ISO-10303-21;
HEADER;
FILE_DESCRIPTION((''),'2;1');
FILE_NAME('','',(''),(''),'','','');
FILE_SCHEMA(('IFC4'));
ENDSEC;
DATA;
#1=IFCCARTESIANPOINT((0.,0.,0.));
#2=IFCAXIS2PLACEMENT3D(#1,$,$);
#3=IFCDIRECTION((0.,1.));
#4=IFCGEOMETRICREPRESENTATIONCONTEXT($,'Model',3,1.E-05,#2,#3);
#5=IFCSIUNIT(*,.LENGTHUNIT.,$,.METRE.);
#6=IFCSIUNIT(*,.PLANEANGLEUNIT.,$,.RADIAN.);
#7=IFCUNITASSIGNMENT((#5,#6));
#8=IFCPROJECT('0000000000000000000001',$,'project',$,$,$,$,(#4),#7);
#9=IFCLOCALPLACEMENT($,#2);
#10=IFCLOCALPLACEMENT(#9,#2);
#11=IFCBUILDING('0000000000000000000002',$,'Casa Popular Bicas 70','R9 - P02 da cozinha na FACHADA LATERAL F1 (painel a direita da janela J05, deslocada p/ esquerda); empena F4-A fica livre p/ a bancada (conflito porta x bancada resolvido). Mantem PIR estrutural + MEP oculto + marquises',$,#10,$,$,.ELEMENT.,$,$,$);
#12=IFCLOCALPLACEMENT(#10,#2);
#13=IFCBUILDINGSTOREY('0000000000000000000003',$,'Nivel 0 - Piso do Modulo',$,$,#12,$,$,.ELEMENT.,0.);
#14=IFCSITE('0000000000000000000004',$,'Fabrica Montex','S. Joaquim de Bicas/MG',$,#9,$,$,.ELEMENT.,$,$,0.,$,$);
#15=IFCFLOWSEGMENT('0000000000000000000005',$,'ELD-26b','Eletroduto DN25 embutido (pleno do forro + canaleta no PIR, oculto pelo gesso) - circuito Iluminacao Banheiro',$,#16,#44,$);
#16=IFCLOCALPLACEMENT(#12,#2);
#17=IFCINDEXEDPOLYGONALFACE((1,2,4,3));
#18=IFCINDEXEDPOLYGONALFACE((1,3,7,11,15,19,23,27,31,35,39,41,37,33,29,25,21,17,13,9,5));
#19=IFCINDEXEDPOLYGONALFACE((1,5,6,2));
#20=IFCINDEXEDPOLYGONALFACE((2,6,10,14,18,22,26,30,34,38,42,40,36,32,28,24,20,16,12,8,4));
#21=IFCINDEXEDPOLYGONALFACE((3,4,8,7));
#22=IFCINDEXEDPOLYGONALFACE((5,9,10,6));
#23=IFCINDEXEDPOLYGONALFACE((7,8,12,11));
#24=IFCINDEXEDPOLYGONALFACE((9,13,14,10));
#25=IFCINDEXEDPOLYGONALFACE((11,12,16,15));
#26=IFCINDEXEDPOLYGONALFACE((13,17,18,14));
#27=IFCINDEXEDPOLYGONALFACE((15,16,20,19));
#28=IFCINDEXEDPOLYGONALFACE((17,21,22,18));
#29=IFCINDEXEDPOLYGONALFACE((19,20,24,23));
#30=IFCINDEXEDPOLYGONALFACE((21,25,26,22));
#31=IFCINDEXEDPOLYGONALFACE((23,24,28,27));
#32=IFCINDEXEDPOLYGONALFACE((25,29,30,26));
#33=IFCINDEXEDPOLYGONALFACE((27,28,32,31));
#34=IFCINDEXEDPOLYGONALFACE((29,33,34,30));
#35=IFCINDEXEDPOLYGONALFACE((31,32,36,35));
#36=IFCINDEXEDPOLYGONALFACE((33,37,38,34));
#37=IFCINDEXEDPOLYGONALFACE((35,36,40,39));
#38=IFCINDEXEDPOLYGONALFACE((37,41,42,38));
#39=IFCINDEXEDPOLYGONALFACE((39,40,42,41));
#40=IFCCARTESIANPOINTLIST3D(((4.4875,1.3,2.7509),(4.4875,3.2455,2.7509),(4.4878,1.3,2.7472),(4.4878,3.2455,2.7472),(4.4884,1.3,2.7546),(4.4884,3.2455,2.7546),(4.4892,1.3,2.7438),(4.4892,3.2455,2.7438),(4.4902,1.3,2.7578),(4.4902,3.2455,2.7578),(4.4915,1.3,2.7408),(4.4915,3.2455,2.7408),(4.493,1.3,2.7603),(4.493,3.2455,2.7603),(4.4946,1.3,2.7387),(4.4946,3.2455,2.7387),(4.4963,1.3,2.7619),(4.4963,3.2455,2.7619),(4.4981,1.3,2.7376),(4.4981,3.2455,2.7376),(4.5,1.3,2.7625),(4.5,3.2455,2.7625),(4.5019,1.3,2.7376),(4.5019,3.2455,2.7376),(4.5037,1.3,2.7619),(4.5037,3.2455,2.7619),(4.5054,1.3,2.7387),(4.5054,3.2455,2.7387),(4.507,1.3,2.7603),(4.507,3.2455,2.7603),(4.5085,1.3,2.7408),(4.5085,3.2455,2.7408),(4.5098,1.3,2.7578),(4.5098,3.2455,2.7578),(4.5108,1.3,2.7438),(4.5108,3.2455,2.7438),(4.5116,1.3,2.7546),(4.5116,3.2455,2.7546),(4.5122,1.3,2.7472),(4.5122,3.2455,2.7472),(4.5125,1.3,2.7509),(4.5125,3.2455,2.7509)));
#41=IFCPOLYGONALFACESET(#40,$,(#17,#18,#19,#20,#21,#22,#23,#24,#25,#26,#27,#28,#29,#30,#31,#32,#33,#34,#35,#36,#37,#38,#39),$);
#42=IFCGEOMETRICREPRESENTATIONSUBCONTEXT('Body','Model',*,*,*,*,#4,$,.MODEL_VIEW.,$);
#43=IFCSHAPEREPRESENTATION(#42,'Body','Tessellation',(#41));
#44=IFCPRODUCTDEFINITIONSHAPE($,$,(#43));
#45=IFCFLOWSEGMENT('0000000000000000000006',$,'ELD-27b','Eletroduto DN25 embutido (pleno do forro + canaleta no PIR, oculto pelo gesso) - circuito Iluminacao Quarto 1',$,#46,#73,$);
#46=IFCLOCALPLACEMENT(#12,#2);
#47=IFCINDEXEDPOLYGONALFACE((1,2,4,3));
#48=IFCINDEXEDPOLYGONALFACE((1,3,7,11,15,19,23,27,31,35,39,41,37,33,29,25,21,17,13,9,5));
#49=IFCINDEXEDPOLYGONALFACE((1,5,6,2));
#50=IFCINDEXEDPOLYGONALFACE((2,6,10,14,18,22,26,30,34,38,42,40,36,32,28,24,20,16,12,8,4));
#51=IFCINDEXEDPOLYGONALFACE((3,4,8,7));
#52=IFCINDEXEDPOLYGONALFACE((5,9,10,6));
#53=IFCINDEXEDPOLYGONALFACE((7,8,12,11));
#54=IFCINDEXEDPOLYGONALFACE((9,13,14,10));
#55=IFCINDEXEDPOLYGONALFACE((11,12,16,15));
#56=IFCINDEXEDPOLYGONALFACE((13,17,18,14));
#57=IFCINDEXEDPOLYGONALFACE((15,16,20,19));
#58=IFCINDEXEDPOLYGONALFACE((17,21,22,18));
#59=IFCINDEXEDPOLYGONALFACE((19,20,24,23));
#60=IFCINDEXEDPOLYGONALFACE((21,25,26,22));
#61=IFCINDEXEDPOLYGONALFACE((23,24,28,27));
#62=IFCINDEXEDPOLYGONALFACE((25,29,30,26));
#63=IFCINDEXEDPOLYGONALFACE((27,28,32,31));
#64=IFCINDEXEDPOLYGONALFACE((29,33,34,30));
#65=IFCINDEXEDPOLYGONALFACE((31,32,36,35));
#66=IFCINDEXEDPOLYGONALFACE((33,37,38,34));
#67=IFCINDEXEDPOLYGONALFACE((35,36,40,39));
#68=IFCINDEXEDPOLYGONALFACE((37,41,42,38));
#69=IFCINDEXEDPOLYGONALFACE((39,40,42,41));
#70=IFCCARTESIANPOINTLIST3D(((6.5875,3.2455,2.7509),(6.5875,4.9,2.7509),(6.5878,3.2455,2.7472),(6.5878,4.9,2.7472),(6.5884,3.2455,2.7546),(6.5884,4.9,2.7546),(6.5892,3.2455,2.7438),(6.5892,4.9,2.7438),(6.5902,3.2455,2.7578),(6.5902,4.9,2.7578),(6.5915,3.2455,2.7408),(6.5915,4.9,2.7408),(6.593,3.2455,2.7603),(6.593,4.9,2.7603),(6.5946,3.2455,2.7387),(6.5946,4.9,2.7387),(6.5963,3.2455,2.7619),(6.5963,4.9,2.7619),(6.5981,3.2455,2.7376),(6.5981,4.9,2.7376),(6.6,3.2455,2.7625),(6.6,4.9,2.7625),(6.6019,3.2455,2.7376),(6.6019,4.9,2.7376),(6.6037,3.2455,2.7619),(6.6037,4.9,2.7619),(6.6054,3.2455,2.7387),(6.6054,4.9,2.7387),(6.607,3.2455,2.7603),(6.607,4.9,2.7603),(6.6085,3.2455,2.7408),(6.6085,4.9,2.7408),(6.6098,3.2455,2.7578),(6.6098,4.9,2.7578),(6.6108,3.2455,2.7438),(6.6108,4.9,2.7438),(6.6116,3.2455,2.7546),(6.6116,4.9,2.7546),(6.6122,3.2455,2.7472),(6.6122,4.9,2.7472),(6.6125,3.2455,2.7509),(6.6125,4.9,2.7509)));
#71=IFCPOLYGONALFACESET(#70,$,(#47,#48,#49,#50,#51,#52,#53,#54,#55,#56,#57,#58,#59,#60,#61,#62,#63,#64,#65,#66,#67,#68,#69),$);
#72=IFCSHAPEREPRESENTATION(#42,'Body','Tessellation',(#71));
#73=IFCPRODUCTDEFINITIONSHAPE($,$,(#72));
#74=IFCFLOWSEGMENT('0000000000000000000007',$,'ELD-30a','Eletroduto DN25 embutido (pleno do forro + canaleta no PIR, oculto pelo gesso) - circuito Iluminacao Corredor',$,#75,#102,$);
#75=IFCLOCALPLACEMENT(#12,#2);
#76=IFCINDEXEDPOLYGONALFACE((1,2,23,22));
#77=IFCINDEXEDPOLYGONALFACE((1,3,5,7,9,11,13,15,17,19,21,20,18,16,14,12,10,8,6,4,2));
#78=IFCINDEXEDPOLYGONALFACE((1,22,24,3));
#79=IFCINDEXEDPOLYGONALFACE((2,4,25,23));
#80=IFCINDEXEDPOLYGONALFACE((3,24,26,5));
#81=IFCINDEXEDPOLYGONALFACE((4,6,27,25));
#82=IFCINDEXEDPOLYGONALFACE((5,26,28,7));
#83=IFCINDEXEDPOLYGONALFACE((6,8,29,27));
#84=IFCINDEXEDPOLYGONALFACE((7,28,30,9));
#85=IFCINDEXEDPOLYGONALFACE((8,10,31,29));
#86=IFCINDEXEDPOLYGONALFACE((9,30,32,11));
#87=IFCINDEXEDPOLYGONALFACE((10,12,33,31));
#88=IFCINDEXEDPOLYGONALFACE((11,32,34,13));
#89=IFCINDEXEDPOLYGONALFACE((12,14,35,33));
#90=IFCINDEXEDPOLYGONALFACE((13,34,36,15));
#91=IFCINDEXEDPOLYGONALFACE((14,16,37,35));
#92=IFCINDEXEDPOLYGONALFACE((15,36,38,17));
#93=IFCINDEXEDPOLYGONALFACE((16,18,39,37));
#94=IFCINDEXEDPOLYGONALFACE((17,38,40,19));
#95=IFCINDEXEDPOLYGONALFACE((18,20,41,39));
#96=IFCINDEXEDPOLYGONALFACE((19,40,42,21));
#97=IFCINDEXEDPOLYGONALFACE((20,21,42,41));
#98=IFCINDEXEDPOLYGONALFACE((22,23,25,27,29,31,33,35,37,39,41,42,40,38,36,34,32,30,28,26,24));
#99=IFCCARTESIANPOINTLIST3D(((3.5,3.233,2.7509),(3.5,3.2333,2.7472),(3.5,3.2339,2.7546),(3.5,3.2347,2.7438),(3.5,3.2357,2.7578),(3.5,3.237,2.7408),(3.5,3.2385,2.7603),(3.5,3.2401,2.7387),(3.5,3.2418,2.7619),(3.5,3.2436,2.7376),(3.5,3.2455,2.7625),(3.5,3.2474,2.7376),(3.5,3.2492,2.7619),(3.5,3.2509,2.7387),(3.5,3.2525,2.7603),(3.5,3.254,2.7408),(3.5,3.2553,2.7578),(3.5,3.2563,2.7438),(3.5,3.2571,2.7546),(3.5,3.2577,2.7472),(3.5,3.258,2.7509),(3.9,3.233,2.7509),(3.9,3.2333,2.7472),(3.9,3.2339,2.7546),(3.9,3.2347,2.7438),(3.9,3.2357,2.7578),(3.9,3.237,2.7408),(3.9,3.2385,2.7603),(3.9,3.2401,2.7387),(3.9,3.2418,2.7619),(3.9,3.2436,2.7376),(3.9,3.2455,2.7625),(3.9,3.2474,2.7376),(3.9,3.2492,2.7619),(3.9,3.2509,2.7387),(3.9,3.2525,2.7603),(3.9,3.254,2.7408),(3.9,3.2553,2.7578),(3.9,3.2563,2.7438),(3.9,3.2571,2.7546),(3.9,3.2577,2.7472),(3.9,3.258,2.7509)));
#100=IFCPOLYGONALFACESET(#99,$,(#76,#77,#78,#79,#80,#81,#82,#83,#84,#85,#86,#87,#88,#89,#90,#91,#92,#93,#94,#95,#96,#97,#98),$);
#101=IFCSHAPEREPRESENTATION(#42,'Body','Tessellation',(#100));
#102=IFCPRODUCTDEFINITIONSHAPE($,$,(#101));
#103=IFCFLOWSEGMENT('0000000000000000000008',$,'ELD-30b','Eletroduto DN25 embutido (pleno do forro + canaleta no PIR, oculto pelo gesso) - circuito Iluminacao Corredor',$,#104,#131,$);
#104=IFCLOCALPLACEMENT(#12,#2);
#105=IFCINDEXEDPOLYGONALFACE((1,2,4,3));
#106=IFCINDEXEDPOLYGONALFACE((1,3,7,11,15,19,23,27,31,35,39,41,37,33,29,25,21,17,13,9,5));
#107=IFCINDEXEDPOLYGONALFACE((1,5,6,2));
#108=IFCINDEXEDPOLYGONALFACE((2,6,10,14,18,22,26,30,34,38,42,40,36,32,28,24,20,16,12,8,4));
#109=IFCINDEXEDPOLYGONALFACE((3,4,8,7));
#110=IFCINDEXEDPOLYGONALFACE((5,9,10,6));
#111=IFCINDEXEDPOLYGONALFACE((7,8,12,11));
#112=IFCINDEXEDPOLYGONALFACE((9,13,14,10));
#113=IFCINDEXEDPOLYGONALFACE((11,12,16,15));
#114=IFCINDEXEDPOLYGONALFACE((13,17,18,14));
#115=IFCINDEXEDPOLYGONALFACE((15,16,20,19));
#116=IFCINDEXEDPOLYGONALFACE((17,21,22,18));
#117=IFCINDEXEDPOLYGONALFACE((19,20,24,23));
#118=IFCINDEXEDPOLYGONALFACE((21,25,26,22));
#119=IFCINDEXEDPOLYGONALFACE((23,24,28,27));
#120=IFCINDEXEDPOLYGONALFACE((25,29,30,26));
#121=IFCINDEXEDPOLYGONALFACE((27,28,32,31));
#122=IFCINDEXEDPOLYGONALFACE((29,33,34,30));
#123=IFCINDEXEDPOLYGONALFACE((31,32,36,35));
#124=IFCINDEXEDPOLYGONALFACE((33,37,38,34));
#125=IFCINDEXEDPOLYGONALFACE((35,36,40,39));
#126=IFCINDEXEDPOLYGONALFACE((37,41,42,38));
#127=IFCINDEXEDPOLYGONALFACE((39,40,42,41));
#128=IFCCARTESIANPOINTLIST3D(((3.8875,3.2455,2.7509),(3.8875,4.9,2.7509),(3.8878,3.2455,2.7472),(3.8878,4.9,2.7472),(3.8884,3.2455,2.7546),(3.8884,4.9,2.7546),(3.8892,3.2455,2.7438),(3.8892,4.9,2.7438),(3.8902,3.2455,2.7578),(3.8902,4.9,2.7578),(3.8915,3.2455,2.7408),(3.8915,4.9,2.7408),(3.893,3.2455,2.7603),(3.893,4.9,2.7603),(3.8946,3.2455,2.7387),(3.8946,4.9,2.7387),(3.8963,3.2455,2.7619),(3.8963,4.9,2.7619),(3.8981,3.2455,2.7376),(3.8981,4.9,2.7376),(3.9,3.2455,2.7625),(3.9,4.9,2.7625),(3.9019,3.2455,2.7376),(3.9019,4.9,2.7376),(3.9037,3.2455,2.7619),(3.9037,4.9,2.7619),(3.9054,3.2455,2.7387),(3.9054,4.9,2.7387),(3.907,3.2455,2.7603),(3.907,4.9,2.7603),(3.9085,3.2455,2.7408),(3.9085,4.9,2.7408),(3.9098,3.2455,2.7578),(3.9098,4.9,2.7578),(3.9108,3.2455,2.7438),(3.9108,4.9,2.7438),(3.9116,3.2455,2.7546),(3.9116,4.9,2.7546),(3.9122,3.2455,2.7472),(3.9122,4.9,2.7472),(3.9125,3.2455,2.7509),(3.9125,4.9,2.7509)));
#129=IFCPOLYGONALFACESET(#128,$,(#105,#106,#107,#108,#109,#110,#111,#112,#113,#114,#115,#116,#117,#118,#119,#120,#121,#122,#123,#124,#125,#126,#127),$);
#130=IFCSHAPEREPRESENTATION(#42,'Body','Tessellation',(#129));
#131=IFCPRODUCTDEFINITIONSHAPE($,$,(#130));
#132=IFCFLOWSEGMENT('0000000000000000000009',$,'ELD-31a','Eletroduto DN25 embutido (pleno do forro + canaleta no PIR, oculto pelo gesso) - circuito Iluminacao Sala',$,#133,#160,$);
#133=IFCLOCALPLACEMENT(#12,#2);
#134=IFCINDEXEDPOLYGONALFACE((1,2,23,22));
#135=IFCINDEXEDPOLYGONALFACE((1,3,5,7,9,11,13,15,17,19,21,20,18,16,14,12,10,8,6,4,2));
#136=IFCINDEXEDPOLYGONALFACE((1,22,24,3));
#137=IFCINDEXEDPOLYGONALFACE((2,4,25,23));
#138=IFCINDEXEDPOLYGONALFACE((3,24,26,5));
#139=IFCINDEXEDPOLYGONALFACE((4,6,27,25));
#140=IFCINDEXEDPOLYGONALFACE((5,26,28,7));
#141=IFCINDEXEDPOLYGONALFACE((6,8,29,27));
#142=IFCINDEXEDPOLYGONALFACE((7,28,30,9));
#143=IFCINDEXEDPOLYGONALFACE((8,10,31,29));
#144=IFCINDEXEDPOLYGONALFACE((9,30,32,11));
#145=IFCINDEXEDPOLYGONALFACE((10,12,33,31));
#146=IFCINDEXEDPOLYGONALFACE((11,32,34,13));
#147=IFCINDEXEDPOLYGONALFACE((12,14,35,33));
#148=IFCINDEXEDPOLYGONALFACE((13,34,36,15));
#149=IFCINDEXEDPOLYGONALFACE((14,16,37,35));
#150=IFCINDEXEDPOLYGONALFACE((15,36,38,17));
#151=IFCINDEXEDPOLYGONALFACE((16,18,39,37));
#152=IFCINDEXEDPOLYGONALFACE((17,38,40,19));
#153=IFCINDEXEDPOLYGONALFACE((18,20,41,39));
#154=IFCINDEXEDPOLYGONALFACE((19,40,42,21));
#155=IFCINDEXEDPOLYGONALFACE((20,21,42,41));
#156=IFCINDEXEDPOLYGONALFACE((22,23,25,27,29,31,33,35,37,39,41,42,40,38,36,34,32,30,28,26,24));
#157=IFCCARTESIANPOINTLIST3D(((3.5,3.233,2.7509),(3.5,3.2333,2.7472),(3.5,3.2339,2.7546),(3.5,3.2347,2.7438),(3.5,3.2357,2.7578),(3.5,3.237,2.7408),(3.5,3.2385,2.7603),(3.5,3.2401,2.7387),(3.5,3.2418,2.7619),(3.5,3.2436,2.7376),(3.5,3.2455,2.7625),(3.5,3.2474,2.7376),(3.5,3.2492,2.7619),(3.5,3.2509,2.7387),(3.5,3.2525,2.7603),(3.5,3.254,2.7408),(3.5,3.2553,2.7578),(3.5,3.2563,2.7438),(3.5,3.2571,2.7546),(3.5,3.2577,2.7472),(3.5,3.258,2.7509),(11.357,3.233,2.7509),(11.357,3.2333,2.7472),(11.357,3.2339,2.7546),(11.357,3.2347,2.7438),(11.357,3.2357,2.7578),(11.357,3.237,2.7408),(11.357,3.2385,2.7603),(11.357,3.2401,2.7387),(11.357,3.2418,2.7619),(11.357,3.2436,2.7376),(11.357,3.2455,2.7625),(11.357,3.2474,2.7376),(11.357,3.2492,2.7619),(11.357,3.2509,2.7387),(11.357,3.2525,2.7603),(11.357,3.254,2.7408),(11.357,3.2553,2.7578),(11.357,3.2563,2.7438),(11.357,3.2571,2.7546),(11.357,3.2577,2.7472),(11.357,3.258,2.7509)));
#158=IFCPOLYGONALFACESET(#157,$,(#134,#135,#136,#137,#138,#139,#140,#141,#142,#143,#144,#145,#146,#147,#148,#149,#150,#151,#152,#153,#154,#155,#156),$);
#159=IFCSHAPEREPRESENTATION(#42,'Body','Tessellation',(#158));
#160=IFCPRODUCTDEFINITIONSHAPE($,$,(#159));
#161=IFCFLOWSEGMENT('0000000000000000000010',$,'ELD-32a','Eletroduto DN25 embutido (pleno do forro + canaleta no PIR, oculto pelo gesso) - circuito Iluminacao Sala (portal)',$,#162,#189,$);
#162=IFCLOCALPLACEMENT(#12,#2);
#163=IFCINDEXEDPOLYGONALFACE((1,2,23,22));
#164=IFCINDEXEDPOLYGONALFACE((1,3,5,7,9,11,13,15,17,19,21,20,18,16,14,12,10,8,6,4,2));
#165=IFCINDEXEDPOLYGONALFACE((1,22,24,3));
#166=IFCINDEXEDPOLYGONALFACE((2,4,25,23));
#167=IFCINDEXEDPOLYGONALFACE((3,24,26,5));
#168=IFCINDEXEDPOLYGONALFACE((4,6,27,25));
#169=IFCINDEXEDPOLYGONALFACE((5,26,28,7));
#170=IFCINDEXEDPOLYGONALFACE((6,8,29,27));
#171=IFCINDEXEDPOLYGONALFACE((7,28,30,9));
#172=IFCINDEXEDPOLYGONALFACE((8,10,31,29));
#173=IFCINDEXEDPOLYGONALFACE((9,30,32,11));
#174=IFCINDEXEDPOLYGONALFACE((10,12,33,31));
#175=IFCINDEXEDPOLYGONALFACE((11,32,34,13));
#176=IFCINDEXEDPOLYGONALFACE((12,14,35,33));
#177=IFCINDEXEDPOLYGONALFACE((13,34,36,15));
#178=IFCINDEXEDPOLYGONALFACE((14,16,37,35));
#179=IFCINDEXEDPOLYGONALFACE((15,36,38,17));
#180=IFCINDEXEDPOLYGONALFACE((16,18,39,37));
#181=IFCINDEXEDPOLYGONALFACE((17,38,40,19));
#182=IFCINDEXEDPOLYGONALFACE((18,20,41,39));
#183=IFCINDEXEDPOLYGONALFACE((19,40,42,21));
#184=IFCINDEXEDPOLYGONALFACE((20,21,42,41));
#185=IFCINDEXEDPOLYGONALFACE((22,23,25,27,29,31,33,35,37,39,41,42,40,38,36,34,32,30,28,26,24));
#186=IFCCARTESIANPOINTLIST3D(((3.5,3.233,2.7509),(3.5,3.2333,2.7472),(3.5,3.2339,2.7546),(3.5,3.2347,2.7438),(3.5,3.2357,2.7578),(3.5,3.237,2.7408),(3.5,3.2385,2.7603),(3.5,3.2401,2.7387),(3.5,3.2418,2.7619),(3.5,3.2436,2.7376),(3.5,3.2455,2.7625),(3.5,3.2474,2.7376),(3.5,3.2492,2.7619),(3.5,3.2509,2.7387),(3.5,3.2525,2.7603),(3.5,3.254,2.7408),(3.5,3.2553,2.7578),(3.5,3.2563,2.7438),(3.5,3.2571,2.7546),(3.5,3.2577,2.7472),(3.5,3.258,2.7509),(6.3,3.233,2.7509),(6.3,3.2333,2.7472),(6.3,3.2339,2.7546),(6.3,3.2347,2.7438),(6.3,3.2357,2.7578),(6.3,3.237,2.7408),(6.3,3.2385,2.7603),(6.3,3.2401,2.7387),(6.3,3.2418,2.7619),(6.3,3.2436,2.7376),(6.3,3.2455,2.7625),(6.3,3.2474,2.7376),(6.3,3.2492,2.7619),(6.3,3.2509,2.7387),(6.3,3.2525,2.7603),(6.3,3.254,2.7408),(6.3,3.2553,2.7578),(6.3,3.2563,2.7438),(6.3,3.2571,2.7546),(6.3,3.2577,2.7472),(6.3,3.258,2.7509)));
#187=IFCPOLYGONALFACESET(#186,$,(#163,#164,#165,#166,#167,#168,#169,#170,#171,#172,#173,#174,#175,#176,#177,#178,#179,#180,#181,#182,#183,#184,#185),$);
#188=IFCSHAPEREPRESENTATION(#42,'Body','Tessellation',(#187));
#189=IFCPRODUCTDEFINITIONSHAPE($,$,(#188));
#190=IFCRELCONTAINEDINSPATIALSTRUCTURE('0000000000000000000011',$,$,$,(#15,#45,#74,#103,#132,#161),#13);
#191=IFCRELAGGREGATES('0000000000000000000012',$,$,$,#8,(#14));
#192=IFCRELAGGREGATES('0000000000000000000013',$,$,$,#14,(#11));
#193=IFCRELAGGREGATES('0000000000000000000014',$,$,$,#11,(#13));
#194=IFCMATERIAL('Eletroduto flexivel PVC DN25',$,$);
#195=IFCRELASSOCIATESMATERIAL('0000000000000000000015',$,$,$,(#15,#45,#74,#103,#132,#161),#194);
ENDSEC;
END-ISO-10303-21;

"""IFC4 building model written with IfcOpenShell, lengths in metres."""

from ifc_helpers import new_model, si_unit, direction, frame, origin, origin_2d, place, context, subcontext, project, spatial, circle, extrude, material, element, save


model = new_model("IFC4")

# Units and contexts
model_context_1 = context("Model", 3, precision=1e-05, world=origin(), true_north=direction((0.0, 1.0)))
body_context_1 = subcontext(model_context_1, "Body", "Model", "MODEL_VIEW")
ifc_project = project(units=[si_unit("LENGTHUNIT", "METRE"), si_unit("PLANEANGLEUNIT", "RADIAN")], contexts=[model_context_1])

# Site, building, storey
site_placement = place(None, origin())
site = spatial("IfcSite", under=ifc_project, at=site_placement, Name="Fabrica Montex", Description="S. Joaquim de Bicas/MG", CompositionType="ELEMENT", RefElevation=0.0)
building_placement = place(site_placement, origin())
building = spatial("IfcBuilding", under=site, at=building_placement, Name="Casa Popular Bicas 70", Description="R9 - P02 da cozinha na FACHADA LATERAL F1 (painel a direita da janela J05, deslocada p/ esquerda); empena F4-A fica livre p/ a bancada (conflito porta x bancada resolvido). Mantem PIR estrutural + MEP oculto + marquises", CompositionType="ELEMENT")
storey_placement = place(building_placement, origin())
storey = spatial("IfcBuildingStorey", under=building, at=storey_placement, Name="Nivel 0 - Piso do Modulo", CompositionType="ELEMENT", Elevation=0.0)

# Flow segments
ifc_material_1 = material(Name="Eletroduto flexivel PVC DN25")
flow_segment_1_placement = place(storey_placement, frame((4.5, 3.2455, 2.75), z_axis=(0.0, -1.0, 0.0), x_axis=(0.0, 0.0, 1.0)))
element("IfcFlowSegment", 1, at=flow_segment_1_placement, inside=storey, material=ifc_material_1, Name="ELD-26b", Description="Eletroduto DN25 embutido (pleno do forro + canaleta no PIR, oculto pelo gesso) - circuito Iluminacao Banheiro", context=body_context_1, shape_type="SweptSolid", body=[
    extrude(circle(Radius=0.0125, at=origin_2d()), origin(), (0.0, 0.0, 1.0), 1.9455),
])
for number, where, z_axis, x_axis, name in (
    (2, (6.6, 3.2455, 2.75), (0.0, 1.0, 0.0), (0.0, 0.0, 1.0), "ELD-27b"),
):
    element("IfcFlowSegment", number, at=place(storey_placement, frame(where, z_axis=z_axis, x_axis=x_axis)), inside=storey, material=ifc_material_1, Name=name, Description="Eletroduto DN25 embutido (pleno do forro + canaleta no PIR, oculto pelo gesso) - circuito Iluminacao Quarto 1", context=body_context_1, shape_type="SweptSolid", body=[
        extrude(circle(Radius=0.0125, at=origin_2d()), origin(), (0.0, 0.0, 1.0), 1.6545),
    ])
flow_segment_2_placement = place(storey_placement, frame((3.5, 3.2455, 2.75), z_axis=(1.0, 0.0, 0.0), x_axis=(0.0, 0.0, 1.0)))
element("IfcFlowSegment", 3, at=flow_segment_2_placement, inside=storey, material=ifc_material_1, Name="ELD-30a", Description="Eletroduto DN25 embutido (pleno do forro + canaleta no PIR, oculto pelo gesso) - circuito Iluminacao Corredor", context=body_context_1, shape_type="SweptSolid", body=[
    extrude(circle(Radius=0.0125, at=origin_2d()), origin(), (0.0, 0.0, 1.0), 0.4),
])
flow_segment_3_placement = place(storey_placement, frame((3.9, 3.2455, 2.75), z_axis=(0.0, 1.0, 0.0), x_axis=(0.0, 0.0, 1.0)))
element("IfcFlowSegment", 4, at=flow_segment_3_placement, inside=storey, material=ifc_material_1, Name="ELD-30b", Description="Eletroduto DN25 embutido (pleno do forro + canaleta no PIR, oculto pelo gesso) - circuito Iluminacao Corredor", context=body_context_1, shape_type="SweptSolid", body=[
    extrude(circle(Radius=0.0125, at=origin_2d()), origin(), (0.0, 0.0, 1.0), 1.6545),
])
flow_segment_4_placement = place(storey_placement, frame((3.5, 3.2455, 2.75), z_axis=(1.0, 0.0, 0.0), x_axis=(0.0, 0.0, 1.0)))
element("IfcFlowSegment", 5, at=flow_segment_4_placement, inside=storey, material=ifc_material_1, Name="ELD-31a", Description="Eletroduto DN25 embutido (pleno do forro + canaleta no PIR, oculto pelo gesso) - circuito Iluminacao Sala", context=body_context_1, shape_type="SweptSolid", body=[
    extrude(circle(Radius=0.0125, at=origin_2d()), origin(), (0.0, 0.0, 1.0), 7.857),
])
flow_segment_5_placement = place(storey_placement, frame((3.5, 3.2455, 2.75), z_axis=(1.0, 0.0, 0.0), x_axis=(0.0, 0.0, 1.0)))
element("IfcFlowSegment", 6, at=flow_segment_5_placement, inside=storey, material=ifc_material_1, Name="ELD-32a", Description="Eletroduto DN25 embutido (pleno do forro + canaleta no PIR, oculto pelo gesso) - circuito Iluminacao Sala (portal)", context=body_context_1, shape_type="SweptSolid", body=[
    extrude(circle(Radius=0.0125, at=origin_2d()), origin(), (0.0, 0.0, 1.0), 2.8),
])

save(model, "model.ifc")
